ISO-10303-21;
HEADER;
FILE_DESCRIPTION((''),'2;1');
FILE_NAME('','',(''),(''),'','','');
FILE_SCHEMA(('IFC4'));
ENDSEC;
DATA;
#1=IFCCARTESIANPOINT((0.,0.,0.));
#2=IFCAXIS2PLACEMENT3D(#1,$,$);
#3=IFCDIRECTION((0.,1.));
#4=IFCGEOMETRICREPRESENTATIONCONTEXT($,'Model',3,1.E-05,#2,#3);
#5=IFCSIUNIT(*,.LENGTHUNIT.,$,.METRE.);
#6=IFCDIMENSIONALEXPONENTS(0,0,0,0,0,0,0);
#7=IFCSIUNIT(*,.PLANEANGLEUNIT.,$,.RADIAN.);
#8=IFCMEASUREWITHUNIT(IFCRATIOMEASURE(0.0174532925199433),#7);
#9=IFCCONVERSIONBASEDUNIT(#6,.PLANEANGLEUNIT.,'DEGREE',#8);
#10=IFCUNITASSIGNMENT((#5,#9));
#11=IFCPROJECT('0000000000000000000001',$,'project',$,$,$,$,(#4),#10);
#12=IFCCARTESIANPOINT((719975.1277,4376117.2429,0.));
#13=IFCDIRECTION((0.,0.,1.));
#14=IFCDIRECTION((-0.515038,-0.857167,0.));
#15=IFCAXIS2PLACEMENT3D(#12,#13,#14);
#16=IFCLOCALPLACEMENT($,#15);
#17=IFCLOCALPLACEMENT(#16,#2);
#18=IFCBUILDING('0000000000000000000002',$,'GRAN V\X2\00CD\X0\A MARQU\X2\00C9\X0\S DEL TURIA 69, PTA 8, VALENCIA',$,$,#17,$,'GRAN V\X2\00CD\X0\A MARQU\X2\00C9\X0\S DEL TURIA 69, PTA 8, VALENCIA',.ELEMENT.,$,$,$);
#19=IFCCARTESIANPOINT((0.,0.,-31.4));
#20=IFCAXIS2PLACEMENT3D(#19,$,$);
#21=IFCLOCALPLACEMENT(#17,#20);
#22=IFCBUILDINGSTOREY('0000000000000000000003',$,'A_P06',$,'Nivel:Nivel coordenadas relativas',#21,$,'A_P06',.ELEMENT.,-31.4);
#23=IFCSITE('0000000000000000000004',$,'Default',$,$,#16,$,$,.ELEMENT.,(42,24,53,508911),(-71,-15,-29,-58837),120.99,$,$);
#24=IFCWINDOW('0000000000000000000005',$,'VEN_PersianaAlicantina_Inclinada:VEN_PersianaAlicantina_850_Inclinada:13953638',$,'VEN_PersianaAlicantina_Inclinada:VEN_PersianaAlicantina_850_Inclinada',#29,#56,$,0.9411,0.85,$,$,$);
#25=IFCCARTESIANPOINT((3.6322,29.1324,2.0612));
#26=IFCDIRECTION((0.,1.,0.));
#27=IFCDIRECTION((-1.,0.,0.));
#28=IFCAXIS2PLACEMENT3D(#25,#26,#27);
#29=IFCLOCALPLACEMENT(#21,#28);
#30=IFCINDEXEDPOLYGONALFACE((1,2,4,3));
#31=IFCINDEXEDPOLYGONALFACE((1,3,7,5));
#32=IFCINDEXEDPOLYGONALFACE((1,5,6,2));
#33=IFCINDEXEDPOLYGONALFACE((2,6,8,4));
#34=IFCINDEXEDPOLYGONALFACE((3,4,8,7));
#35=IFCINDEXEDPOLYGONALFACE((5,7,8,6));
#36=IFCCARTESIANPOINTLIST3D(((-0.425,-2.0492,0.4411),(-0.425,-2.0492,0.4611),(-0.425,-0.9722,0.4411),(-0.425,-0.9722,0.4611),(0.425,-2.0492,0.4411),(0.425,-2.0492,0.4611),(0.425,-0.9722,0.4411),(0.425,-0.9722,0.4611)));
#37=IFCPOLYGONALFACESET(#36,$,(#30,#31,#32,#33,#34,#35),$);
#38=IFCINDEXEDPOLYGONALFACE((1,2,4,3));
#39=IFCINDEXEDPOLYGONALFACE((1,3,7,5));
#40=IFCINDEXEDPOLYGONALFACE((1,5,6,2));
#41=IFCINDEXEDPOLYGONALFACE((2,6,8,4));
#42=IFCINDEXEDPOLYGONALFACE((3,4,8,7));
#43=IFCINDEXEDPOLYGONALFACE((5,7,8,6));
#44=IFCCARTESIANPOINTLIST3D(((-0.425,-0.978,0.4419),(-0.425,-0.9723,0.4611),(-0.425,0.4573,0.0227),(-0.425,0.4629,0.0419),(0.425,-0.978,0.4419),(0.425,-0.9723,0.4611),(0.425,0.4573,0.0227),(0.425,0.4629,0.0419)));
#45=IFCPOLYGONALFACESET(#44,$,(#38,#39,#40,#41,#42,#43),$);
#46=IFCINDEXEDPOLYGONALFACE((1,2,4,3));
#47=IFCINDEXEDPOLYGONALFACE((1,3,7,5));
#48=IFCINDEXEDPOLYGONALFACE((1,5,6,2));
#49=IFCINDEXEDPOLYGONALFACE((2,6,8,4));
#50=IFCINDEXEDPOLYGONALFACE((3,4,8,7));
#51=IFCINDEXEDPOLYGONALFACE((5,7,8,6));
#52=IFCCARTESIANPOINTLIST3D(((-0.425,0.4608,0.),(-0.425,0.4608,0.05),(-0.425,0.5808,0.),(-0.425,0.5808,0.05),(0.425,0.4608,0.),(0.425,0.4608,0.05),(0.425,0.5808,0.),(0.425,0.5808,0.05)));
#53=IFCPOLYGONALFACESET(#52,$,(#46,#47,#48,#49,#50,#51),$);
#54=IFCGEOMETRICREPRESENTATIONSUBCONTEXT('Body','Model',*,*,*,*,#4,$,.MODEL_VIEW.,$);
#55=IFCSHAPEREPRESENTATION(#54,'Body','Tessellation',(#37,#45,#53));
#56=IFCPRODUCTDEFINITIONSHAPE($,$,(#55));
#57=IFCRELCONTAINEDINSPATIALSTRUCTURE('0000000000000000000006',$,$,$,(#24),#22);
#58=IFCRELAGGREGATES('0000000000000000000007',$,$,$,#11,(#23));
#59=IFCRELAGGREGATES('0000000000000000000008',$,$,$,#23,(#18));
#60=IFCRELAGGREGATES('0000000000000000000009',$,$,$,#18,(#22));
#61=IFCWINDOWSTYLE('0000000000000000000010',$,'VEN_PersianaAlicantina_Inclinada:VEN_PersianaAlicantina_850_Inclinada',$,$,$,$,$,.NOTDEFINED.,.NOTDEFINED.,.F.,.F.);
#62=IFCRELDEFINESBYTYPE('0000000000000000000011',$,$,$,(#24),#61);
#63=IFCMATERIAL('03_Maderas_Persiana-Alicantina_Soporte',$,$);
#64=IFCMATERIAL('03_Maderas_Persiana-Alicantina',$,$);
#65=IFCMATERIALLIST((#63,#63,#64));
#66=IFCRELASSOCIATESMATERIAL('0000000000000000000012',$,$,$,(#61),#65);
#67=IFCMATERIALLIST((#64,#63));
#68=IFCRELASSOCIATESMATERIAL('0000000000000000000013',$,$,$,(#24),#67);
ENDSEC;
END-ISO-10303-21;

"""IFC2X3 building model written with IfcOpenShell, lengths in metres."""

from ifc_helpers import new_model, entity, si_unit, converted_unit, direction, frame, frame_2d, origin, place, context, subcontext, project, spatial, rectangle, extrude, source, transform, mapped, material, material_list, type_object, type_shapes, element, save


model = new_model("IFC2X3")

# Units and contexts
model_context = context("Model", 3, precision=1e-05, world=origin(), true_north=direction((0.0, 1.0)))
body_context = subcontext(model_context, "Body", "Model", "MODEL_VIEW")
ifc_project = project(units=[si_unit("LENGTHUNIT", "METRE"), converted_unit("PLANEANGLEUNIT", "DEGREE", entity("IfcRatioMeasure", 0.0174532925199433), si_unit("PLANEANGLEUNIT", "RADIAN"), dimensions=[0, 0, 0, 0, 0, 0, 0])], contexts=[model_context])

# Site, building, storey
site_placement = place(None, frame((719975.1277, 4376117.2429, 0.0), z_axis=(0.0, 0.0, 1.0), x_axis=(-0.515038, -0.857167, 0.0)))
site = spatial("IfcSite", under=ifc_project, at=site_placement, Name="Default", CompositionType="ELEMENT", RefLatitude=(42, 24, 53, 508911), RefLongitude=(-71, -15, -29, -58837), RefElevation=120.99)
building_placement = place(site_placement, origin())
building = spatial("IfcBuilding", under=site, at=building_placement, Name="GRAN VÍA MARQUÉS DEL TURIA 69, PTA 8, VALENCIA", LongName="GRAN VÍA MARQUÉS DEL TURIA 69, PTA 8, VALENCIA", CompositionType="ELEMENT")
storey_placement = place(building_placement, frame((0.0, 0.0, -31.4)))
storey = spatial("IfcBuildingStorey", under=building, at=storey_placement, Name="A_P06", ObjectType="Nivel:Nivel coordenadas relativas", LongName="A_P06", CompositionType="ELEMENT", Elevation=-31.4)

# Window
ifc_material_1 = material(Name="03_Maderas_Persiana-Alicantina_Soporte")
ifc_material_2 = material(Name="03_Maderas_Persiana-Alicantina")
ifc_material_list_1 = material_list([ifc_material_2, ifc_material_1])
ifc_material_list_2 = material_list([ifc_material_1, ifc_material_1, ifc_material_2])
window_style_1 = type_object("IfcWindowStyle", Name="VEN_PersianaAlicantina_Inclinada:VEN_PersianaAlicantina_850_Inclinada", ConstructionType="NOTDEFINED", OperationType="NOTDEFINED", ParameterTakesPrecedence=False, Sizeable=False, material=ifc_material_list_2)
shared_shape_1 = source(origin(), body_context, "Body", "SweptSolid", [
    extrude(rectangle(XDim=0.85, YDim=1.077, at=frame_2d((0.0, 0.0), x_axis=(1.0, 0.0))), frame((0.0, -1.5107, 0.4411), z_axis=(0.0, 0.0, 1.0), x_axis=(-1.0, 0.0, 0.0)), (0.0, 0.0, 1.0), 0.02),
    extrude(rectangle(XDim=0.02, YDim=1.4953, at=frame_2d((0.0, 0.0), x_axis=(0.0, 1.0))), frame((-0.425, -0.2575, 0.2419), z_axis=(1.0, 0.0, 0.0), x_axis=(0.0, 0.959885, -0.280394)), (0.0, 0.0, 1.0), 0.85),
    extrude(rectangle(XDim=0.85, YDim=0.12, at=frame_2d((0.0, 0.0), x_axis=(1.0, 0.0))), frame((0.0, 0.5208, 0.0), z_axis=(0.0, 0.0, 1.0), x_axis=(-1.0, 0.0, 0.0)), (0.0, 0.0, 1.0), 0.05),
])
type_shapes(window_style_1, [shared_shape_1])
window_1_placement = place(storey_placement, frame((3.6322, 29.1324, 2.0612), z_axis=(0.0, 1.0, 0.0), x_axis=(-1.0, 0.0, 0.0)))
element("IfcWindow", 1, at=window_1_placement, inside=storey, type_object=window_style_1, material=ifc_material_list_1, Name="VEN_PersianaAlicantina_Inclinada:VEN_PersianaAlicantina_850_Inclinada:13953638", ObjectType="VEN_PersianaAlicantina_Inclinada:VEN_PersianaAlicantina_850_Inclinada", OverallHeight=0.9411, OverallWidth=0.85, context=body_context, shape_type="MappedRepresentation", body=[
    mapped(shared_shape_1, transform((0.0, 0.0, 0.0), scale=1.0)),
])

save(model, "model.ifc")
